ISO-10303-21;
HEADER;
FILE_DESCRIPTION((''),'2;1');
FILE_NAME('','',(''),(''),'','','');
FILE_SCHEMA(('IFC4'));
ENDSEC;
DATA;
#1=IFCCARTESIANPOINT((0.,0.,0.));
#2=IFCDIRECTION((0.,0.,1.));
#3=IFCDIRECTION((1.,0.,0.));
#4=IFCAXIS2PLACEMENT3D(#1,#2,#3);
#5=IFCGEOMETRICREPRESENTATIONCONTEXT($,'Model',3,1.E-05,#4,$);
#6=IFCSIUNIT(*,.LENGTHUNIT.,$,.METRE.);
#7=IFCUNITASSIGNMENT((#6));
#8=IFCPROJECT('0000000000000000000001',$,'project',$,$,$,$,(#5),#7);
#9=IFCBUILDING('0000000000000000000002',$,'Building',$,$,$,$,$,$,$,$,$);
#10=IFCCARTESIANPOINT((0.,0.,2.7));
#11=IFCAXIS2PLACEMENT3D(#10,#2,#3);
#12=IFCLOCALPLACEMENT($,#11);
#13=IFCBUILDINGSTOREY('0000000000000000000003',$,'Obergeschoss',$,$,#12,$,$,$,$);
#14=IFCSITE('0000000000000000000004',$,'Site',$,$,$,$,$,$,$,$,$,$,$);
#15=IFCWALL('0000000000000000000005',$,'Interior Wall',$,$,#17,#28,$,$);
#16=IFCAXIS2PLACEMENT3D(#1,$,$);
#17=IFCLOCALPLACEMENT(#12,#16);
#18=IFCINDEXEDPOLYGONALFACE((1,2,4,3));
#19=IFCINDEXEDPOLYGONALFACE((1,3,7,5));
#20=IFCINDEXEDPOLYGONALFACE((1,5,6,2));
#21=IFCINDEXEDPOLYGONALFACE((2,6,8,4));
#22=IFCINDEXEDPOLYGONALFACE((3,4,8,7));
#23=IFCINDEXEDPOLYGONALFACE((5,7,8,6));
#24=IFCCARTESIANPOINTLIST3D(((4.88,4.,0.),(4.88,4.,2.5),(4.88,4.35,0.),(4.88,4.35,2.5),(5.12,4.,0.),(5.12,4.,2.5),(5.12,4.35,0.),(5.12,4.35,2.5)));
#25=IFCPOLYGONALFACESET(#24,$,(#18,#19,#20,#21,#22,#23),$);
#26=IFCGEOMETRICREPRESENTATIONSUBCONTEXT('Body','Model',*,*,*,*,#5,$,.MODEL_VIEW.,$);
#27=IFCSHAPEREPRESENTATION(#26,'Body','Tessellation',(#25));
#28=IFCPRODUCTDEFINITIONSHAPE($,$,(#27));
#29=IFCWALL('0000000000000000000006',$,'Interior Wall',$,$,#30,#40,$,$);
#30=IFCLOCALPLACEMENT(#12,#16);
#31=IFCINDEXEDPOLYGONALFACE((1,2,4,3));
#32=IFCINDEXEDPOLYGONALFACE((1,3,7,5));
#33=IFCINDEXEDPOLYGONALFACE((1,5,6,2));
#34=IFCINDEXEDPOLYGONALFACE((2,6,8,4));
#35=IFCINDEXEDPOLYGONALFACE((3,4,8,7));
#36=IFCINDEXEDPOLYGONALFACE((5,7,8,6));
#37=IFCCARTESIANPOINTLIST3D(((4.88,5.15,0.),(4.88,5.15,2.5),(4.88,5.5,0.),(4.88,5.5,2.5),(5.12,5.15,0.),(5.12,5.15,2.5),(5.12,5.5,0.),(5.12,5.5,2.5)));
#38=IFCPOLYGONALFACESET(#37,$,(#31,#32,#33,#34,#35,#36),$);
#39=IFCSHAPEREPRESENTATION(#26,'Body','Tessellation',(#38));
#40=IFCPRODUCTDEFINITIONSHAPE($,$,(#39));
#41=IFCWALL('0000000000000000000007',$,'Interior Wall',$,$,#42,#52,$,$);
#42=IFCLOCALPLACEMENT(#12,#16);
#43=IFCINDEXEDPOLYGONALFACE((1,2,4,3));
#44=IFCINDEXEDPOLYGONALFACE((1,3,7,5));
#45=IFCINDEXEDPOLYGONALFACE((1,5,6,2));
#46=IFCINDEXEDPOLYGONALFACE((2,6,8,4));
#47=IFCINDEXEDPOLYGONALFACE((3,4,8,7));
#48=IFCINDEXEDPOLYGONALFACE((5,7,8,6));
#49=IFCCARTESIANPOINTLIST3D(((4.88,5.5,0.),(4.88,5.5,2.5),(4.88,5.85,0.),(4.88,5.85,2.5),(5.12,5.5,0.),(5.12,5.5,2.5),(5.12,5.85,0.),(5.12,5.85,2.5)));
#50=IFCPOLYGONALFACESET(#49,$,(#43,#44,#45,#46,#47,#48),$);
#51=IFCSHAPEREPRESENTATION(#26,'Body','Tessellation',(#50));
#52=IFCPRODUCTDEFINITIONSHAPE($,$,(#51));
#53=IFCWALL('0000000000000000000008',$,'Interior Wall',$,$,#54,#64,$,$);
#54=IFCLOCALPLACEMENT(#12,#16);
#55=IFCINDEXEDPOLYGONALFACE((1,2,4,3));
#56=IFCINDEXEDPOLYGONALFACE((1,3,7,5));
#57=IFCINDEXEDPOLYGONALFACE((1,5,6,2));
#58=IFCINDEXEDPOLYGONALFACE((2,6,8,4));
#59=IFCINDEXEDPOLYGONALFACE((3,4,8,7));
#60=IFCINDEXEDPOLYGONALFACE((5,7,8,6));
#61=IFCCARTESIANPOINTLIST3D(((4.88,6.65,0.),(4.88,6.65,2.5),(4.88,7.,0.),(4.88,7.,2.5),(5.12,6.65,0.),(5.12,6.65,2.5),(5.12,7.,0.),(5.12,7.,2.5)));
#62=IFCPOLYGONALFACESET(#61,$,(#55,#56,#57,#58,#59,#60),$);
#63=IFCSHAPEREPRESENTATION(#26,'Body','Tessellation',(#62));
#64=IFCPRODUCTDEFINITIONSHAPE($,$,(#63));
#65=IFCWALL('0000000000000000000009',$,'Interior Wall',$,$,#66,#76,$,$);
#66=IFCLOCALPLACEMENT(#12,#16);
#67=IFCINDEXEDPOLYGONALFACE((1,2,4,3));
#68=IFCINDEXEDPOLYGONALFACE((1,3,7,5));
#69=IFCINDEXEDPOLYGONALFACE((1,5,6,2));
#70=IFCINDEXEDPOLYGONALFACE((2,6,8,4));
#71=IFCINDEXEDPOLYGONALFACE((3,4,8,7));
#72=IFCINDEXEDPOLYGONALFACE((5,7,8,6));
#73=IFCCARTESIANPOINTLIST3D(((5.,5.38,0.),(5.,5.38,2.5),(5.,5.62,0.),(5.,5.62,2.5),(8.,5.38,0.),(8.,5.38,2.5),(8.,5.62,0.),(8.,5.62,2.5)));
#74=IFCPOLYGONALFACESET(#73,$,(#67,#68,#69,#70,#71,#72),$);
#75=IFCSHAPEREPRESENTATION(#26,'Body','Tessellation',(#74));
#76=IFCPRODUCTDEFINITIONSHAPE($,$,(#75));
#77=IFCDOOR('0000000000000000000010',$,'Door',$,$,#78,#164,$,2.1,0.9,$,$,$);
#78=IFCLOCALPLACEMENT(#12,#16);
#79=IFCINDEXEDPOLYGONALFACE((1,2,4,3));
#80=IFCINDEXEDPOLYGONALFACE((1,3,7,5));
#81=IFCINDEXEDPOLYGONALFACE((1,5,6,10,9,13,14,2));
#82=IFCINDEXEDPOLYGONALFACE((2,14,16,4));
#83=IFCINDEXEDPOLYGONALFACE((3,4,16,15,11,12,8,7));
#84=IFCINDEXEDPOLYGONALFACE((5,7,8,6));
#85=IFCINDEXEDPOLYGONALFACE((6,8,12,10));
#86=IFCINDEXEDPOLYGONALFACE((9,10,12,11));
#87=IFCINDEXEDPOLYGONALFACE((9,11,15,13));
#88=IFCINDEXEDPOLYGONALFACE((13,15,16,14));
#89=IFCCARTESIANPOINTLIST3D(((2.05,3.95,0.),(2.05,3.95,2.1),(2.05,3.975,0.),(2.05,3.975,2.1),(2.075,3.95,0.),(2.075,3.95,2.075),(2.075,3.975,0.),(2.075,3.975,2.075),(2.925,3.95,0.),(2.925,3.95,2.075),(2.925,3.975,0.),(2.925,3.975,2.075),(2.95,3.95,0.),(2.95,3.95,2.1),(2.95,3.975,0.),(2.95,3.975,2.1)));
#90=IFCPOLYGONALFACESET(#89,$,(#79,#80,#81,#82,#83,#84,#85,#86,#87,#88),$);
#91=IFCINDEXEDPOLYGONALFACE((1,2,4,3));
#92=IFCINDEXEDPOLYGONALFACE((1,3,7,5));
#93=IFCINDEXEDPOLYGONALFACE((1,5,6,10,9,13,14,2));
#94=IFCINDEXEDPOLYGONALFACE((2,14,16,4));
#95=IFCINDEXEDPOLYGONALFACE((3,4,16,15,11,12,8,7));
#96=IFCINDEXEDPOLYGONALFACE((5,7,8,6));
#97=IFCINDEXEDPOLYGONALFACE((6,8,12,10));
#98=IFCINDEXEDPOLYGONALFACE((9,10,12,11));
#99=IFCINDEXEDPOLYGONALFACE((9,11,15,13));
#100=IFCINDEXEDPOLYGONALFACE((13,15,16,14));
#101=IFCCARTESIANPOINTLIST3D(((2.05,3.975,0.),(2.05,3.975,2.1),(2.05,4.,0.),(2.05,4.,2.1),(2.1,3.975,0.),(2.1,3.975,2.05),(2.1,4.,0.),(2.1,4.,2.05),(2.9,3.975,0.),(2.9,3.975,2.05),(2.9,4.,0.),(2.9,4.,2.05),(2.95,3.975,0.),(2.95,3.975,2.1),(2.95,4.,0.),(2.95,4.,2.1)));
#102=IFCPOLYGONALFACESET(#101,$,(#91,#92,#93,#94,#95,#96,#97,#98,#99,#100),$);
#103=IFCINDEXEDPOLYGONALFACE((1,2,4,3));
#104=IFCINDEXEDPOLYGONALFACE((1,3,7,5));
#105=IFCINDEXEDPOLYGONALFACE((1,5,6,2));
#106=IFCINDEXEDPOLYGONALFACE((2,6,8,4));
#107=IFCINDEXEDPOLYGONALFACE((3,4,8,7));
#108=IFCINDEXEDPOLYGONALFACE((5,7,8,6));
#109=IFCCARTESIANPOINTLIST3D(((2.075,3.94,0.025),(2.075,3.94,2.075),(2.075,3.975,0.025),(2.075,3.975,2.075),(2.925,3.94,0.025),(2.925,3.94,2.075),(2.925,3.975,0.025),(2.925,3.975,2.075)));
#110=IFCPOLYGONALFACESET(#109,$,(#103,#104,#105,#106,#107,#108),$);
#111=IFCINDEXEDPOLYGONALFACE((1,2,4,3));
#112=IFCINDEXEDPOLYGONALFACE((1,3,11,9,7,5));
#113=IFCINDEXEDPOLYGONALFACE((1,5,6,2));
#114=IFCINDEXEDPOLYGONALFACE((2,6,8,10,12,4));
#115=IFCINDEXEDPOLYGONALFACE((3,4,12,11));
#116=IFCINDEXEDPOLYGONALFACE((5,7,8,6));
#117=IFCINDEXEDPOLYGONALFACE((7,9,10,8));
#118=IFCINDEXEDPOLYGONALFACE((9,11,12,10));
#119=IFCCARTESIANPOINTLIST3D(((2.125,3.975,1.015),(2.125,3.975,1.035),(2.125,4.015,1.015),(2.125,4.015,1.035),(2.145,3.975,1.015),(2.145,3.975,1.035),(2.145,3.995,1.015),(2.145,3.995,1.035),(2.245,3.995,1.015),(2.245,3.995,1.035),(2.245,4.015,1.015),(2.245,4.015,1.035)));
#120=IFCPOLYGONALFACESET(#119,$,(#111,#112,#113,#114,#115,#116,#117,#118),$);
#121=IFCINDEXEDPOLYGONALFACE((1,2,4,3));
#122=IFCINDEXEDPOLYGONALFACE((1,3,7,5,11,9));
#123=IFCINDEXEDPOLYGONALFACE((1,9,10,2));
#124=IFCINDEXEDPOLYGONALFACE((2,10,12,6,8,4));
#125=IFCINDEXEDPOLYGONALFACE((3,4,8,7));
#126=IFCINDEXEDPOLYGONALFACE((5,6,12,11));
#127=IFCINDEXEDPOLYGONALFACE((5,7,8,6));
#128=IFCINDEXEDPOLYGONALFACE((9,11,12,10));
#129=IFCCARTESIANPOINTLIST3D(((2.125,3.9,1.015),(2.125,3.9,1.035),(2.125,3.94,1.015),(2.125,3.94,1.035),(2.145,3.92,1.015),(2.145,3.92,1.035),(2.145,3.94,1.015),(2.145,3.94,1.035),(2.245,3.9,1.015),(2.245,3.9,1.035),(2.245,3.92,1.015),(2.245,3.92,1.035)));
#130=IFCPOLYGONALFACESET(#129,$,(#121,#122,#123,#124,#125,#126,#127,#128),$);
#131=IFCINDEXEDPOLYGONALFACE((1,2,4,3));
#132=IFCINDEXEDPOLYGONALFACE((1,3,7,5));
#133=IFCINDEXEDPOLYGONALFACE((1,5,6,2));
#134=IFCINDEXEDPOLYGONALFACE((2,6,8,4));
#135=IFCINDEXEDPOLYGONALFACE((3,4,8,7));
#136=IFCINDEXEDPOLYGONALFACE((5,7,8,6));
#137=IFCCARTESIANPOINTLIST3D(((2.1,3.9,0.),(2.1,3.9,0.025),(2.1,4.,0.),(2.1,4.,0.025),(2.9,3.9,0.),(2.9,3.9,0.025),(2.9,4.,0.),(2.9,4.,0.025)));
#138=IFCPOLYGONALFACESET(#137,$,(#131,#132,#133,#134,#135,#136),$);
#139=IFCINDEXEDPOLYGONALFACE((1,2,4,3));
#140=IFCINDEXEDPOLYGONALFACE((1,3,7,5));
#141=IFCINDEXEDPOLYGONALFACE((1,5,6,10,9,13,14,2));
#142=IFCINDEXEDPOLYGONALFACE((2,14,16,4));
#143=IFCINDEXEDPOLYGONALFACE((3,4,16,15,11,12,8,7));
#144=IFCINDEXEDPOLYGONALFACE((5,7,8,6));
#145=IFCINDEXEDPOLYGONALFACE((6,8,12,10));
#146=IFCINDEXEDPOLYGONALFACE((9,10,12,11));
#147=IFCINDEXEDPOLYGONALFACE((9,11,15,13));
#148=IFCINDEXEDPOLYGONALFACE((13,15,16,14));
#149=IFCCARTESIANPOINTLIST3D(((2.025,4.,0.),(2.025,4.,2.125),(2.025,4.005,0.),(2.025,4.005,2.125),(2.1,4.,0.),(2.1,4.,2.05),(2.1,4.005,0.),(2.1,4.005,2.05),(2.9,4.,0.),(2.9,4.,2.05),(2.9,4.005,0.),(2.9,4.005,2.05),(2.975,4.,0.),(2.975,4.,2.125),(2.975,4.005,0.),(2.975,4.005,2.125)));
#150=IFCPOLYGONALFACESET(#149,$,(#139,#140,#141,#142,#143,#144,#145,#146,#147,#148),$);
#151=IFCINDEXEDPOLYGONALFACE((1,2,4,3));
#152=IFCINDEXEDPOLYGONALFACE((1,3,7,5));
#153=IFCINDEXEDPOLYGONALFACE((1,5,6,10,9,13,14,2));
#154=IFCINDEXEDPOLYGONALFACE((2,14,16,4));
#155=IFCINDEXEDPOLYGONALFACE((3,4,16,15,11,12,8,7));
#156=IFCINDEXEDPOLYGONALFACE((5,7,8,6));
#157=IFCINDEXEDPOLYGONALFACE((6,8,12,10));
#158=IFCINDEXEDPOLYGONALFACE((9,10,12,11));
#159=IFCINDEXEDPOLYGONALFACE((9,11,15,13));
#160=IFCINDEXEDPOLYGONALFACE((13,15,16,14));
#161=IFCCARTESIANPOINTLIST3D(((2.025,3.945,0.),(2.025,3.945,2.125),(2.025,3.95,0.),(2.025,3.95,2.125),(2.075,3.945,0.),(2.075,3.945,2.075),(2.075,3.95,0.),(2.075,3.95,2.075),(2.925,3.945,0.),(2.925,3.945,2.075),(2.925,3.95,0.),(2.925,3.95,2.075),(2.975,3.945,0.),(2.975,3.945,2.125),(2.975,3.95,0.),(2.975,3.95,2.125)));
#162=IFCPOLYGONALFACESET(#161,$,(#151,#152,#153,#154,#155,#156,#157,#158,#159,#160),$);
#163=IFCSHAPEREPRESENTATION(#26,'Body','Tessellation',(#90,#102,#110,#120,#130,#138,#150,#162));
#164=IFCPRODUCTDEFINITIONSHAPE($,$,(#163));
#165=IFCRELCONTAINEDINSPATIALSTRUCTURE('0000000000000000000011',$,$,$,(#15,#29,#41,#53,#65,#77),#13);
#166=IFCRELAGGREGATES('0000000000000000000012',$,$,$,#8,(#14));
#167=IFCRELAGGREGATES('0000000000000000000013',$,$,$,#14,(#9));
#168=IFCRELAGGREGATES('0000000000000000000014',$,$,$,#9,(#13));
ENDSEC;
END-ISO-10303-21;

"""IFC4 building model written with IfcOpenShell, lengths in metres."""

from ifc_helpers import new_model, si_unit, frame, origin_with_axes, place, context, subcontext, project, spatial, line, indexed_curve, outline, extrude, element, save


model = new_model("IFC4")

# Units and contexts
model_context = context("Model", 3, precision=1e-05, world=origin_with_axes())
body_context = subcontext(model_context, "Body", "Model", "MODEL_VIEW")
ifc_project = project(units=[si_unit("LENGTHUNIT", "METRE")], contexts=[model_context])

# Site, building, storey
site = spatial("IfcSite", under=ifc_project, Name="Site")
building = spatial("IfcBuilding", under=site, Name="Building")
storey_placement = place(None, frame((0.0, 0.0, 2.7), z_axis=(0.0, 0.0, 1.0), x_axis=(1.0, 0.0, 0.0)))
storey = spatial("IfcBuildingStorey", under=building, at=storey_placement, Name="Obergeschoss")

# Walls
for number, where, z_axis, x_axis, name in (
    (1, (5.0, 4.0, 0.0), (0.0, 0.0, 1.0), (0.0, 1.0, 0.0), "Interior Wall"),
    (2, (5.0, 5.15, 0.0), (0.0, 0.0, 1.0), (0.0, 1.0, 0.0), "Interior Wall"),
    (3, (5.0, 5.5, 0.0), (0.0, 0.0, 1.0), (0.0, 1.0, 0.0), "Interior Wall"),
    (4, (5.0, 6.65, 0.0), (0.0, 0.0, 1.0), (0.0, 1.0, 0.0), "Interior Wall"),
):
    element("IfcWall", number, at=place(storey_placement, frame(where, z_axis=z_axis, x_axis=x_axis)), inside=storey, Name=name, context=body_context, shape_type="SweptSolid", body=[
        extrude(outline(indexed_curve([(0.0, 0.0), (0.0, 0.24), (0.35, 0.24), (0.35, 0.0), (0.0, 0.0)], self_intersect=False)), frame((0.0, -0.12, 0.0), z_axis=(0.0, 0.0, 1.0), x_axis=(1.0, 0.0, 0.0)), (0.0, 0.0, 1.0), 2.5),
    ])
wall_1_placement = place(storey_placement, frame((8.0, 5.5, 0.0), z_axis=(0.0, 0.0, 1.0), x_axis=(-1.0, 0.0, 0.0)))
element("IfcWall", 5, at=wall_1_placement, inside=storey, Name="Interior Wall", context=body_context, shape_type="SweptSolid", body=[
    extrude(outline(indexed_curve([(0.0, 0.0), (0.0, 0.24), (3.0, 0.24), (3.0, 0.0), (0.0, 0.0)], self_intersect=False)), frame((0.0, -0.12, 0.0), z_axis=(0.0, 0.0, 1.0), x_axis=(1.0, 0.0, 0.0)), (0.0, 0.0, 1.0), 2.5),
])

# Door
door_1_placement = place(storey_placement, frame((2.95, 4.0, 0.0), z_axis=(0.0, 0.0, 1.0), x_axis=(-1.0, 0.0, 0.0)))
element("IfcDoor", 6, at=door_1_placement, inside=storey, Name="Door", OverallHeight=2.1, OverallWidth=0.9, context=body_context, shape_type="SweptSolid", body=[
    extrude(outline(indexed_curve([(0.0, 0.0), (0.0, 2.1), (0.9, 2.1), (0.9, 0.0), (0.875, 0.0), (0.875, 2.075), (0.025, 2.075), (0.025, 0.0)], segments=[line(1, 2, 3, 4, 5, 6, 7, 8, 1)])), frame((0.0, 0.025, 0.0), z_axis=(0.0, -1.0, 0.0), x_axis=(1.0, 0.0, 0.0)), (0.0, 0.0, -1.0), 0.025),
    extrude(outline(indexed_curve([(0.0, 0.0), (0.0, 2.1), (0.9, 2.1), (0.9, 0.0), (0.85, 0.0), (0.85, 2.05), (0.05, 2.05), (0.05, 0.0)], segments=[line(1, 2, 3, 4, 5, 6, 7, 8, 1)])), frame((0.0, 0.0, 0.0), z_axis=(0.0, -1.0, 0.0), x_axis=(1.0, 0.0, 0.0)), (0.0, 0.0, -1.0), 0.025),
    extrude(outline(indexed_curve([(0.0, 0.0), (0.85, 0.0), (0.85, 0.035), (0.0, 0.035)], segments=[line(1, 2, 3, 4, 1)])), frame((0.025, 0.025, 0.025), z_axis=(0.0, 0.0, 1.0), x_axis=(1.0, 0.0, 0.0)), (0.0, 0.0, 1.0), 2.05),
    extrude(outline(indexed_curve([(0.0, 0.0), (0.0, -0.04), (-0.12, -0.04), (-0.12, -0.02), (-0.02, -0.02), (-0.02, 0.0)], segments=[line(1, 2, 3, 4, 5, 6, 1)])), frame((0.825, 0.025, 1.015), z_axis=(0.0, 0.0, 1.0), x_axis=(1.0, 0.0, 0.0)), (0.0, 0.0, 1.0), 0.02),
    extrude(outline(indexed_curve([(0.0, 0.0), (0.0, 0.04), (-0.12, 0.04), (-0.12, 0.02), (-0.02, 0.02), (-0.02, 0.0)], segments=[line(1, 2, 3, 4, 5, 6, 1)])), frame((0.825, 0.06, 1.015), z_axis=(0.0, 0.0, 1.0), x_axis=(1.0, 0.0, 0.0)), (0.0, 0.0, 1.0), 0.02),
    extrude(outline(indexed_curve([(0.0, 0.0), (0.8, 0.0), (0.8, 0.1), (0.0, 0.1)], segments=[line(1, 2, 3, 4, 1)])), frame((0.05, 0.0, 0.0), z_axis=(0.0, 0.0, 1.0), x_axis=(1.0, 0.0, 0.0)), (0.0, 0.0, 1.0), 0.025),
    extrude(outline(indexed_curve([(0.0, 0.0), (0.0, 2.125), (0.95, 2.125), (0.95, 0.0), (0.875, 0.0), (0.875, 2.05), (0.075, 2.05), (0.075, 0.0)], segments=[line(1, 2, 3, 4, 5, 6, 7, 8, 1)])), frame((-0.025, -0.005, 0.0), z_axis=(0.0, -1.0, 0.0), x_axis=(1.0, 0.0, 0.0)), (0.0, 0.0, -1.0), 0.005),
    extrude(outline(indexed_curve([(0.0, 0.0), (0.0, 2.125), (0.95, 2.125), (0.95, 0.0), (0.9, 0.0), (0.9, 2.075), (0.05, 2.075), (0.05, 0.0)], segments=[line(1, 2, 3, 4, 5, 6, 7, 8, 1)])), frame((-0.025, 0.05, 0.0), z_axis=(0.0, -1.0, 0.0), x_axis=(1.0, 0.0, 0.0)), (0.0, 0.0, -1.0), 0.005),
])

save(model, "model.ifc")
